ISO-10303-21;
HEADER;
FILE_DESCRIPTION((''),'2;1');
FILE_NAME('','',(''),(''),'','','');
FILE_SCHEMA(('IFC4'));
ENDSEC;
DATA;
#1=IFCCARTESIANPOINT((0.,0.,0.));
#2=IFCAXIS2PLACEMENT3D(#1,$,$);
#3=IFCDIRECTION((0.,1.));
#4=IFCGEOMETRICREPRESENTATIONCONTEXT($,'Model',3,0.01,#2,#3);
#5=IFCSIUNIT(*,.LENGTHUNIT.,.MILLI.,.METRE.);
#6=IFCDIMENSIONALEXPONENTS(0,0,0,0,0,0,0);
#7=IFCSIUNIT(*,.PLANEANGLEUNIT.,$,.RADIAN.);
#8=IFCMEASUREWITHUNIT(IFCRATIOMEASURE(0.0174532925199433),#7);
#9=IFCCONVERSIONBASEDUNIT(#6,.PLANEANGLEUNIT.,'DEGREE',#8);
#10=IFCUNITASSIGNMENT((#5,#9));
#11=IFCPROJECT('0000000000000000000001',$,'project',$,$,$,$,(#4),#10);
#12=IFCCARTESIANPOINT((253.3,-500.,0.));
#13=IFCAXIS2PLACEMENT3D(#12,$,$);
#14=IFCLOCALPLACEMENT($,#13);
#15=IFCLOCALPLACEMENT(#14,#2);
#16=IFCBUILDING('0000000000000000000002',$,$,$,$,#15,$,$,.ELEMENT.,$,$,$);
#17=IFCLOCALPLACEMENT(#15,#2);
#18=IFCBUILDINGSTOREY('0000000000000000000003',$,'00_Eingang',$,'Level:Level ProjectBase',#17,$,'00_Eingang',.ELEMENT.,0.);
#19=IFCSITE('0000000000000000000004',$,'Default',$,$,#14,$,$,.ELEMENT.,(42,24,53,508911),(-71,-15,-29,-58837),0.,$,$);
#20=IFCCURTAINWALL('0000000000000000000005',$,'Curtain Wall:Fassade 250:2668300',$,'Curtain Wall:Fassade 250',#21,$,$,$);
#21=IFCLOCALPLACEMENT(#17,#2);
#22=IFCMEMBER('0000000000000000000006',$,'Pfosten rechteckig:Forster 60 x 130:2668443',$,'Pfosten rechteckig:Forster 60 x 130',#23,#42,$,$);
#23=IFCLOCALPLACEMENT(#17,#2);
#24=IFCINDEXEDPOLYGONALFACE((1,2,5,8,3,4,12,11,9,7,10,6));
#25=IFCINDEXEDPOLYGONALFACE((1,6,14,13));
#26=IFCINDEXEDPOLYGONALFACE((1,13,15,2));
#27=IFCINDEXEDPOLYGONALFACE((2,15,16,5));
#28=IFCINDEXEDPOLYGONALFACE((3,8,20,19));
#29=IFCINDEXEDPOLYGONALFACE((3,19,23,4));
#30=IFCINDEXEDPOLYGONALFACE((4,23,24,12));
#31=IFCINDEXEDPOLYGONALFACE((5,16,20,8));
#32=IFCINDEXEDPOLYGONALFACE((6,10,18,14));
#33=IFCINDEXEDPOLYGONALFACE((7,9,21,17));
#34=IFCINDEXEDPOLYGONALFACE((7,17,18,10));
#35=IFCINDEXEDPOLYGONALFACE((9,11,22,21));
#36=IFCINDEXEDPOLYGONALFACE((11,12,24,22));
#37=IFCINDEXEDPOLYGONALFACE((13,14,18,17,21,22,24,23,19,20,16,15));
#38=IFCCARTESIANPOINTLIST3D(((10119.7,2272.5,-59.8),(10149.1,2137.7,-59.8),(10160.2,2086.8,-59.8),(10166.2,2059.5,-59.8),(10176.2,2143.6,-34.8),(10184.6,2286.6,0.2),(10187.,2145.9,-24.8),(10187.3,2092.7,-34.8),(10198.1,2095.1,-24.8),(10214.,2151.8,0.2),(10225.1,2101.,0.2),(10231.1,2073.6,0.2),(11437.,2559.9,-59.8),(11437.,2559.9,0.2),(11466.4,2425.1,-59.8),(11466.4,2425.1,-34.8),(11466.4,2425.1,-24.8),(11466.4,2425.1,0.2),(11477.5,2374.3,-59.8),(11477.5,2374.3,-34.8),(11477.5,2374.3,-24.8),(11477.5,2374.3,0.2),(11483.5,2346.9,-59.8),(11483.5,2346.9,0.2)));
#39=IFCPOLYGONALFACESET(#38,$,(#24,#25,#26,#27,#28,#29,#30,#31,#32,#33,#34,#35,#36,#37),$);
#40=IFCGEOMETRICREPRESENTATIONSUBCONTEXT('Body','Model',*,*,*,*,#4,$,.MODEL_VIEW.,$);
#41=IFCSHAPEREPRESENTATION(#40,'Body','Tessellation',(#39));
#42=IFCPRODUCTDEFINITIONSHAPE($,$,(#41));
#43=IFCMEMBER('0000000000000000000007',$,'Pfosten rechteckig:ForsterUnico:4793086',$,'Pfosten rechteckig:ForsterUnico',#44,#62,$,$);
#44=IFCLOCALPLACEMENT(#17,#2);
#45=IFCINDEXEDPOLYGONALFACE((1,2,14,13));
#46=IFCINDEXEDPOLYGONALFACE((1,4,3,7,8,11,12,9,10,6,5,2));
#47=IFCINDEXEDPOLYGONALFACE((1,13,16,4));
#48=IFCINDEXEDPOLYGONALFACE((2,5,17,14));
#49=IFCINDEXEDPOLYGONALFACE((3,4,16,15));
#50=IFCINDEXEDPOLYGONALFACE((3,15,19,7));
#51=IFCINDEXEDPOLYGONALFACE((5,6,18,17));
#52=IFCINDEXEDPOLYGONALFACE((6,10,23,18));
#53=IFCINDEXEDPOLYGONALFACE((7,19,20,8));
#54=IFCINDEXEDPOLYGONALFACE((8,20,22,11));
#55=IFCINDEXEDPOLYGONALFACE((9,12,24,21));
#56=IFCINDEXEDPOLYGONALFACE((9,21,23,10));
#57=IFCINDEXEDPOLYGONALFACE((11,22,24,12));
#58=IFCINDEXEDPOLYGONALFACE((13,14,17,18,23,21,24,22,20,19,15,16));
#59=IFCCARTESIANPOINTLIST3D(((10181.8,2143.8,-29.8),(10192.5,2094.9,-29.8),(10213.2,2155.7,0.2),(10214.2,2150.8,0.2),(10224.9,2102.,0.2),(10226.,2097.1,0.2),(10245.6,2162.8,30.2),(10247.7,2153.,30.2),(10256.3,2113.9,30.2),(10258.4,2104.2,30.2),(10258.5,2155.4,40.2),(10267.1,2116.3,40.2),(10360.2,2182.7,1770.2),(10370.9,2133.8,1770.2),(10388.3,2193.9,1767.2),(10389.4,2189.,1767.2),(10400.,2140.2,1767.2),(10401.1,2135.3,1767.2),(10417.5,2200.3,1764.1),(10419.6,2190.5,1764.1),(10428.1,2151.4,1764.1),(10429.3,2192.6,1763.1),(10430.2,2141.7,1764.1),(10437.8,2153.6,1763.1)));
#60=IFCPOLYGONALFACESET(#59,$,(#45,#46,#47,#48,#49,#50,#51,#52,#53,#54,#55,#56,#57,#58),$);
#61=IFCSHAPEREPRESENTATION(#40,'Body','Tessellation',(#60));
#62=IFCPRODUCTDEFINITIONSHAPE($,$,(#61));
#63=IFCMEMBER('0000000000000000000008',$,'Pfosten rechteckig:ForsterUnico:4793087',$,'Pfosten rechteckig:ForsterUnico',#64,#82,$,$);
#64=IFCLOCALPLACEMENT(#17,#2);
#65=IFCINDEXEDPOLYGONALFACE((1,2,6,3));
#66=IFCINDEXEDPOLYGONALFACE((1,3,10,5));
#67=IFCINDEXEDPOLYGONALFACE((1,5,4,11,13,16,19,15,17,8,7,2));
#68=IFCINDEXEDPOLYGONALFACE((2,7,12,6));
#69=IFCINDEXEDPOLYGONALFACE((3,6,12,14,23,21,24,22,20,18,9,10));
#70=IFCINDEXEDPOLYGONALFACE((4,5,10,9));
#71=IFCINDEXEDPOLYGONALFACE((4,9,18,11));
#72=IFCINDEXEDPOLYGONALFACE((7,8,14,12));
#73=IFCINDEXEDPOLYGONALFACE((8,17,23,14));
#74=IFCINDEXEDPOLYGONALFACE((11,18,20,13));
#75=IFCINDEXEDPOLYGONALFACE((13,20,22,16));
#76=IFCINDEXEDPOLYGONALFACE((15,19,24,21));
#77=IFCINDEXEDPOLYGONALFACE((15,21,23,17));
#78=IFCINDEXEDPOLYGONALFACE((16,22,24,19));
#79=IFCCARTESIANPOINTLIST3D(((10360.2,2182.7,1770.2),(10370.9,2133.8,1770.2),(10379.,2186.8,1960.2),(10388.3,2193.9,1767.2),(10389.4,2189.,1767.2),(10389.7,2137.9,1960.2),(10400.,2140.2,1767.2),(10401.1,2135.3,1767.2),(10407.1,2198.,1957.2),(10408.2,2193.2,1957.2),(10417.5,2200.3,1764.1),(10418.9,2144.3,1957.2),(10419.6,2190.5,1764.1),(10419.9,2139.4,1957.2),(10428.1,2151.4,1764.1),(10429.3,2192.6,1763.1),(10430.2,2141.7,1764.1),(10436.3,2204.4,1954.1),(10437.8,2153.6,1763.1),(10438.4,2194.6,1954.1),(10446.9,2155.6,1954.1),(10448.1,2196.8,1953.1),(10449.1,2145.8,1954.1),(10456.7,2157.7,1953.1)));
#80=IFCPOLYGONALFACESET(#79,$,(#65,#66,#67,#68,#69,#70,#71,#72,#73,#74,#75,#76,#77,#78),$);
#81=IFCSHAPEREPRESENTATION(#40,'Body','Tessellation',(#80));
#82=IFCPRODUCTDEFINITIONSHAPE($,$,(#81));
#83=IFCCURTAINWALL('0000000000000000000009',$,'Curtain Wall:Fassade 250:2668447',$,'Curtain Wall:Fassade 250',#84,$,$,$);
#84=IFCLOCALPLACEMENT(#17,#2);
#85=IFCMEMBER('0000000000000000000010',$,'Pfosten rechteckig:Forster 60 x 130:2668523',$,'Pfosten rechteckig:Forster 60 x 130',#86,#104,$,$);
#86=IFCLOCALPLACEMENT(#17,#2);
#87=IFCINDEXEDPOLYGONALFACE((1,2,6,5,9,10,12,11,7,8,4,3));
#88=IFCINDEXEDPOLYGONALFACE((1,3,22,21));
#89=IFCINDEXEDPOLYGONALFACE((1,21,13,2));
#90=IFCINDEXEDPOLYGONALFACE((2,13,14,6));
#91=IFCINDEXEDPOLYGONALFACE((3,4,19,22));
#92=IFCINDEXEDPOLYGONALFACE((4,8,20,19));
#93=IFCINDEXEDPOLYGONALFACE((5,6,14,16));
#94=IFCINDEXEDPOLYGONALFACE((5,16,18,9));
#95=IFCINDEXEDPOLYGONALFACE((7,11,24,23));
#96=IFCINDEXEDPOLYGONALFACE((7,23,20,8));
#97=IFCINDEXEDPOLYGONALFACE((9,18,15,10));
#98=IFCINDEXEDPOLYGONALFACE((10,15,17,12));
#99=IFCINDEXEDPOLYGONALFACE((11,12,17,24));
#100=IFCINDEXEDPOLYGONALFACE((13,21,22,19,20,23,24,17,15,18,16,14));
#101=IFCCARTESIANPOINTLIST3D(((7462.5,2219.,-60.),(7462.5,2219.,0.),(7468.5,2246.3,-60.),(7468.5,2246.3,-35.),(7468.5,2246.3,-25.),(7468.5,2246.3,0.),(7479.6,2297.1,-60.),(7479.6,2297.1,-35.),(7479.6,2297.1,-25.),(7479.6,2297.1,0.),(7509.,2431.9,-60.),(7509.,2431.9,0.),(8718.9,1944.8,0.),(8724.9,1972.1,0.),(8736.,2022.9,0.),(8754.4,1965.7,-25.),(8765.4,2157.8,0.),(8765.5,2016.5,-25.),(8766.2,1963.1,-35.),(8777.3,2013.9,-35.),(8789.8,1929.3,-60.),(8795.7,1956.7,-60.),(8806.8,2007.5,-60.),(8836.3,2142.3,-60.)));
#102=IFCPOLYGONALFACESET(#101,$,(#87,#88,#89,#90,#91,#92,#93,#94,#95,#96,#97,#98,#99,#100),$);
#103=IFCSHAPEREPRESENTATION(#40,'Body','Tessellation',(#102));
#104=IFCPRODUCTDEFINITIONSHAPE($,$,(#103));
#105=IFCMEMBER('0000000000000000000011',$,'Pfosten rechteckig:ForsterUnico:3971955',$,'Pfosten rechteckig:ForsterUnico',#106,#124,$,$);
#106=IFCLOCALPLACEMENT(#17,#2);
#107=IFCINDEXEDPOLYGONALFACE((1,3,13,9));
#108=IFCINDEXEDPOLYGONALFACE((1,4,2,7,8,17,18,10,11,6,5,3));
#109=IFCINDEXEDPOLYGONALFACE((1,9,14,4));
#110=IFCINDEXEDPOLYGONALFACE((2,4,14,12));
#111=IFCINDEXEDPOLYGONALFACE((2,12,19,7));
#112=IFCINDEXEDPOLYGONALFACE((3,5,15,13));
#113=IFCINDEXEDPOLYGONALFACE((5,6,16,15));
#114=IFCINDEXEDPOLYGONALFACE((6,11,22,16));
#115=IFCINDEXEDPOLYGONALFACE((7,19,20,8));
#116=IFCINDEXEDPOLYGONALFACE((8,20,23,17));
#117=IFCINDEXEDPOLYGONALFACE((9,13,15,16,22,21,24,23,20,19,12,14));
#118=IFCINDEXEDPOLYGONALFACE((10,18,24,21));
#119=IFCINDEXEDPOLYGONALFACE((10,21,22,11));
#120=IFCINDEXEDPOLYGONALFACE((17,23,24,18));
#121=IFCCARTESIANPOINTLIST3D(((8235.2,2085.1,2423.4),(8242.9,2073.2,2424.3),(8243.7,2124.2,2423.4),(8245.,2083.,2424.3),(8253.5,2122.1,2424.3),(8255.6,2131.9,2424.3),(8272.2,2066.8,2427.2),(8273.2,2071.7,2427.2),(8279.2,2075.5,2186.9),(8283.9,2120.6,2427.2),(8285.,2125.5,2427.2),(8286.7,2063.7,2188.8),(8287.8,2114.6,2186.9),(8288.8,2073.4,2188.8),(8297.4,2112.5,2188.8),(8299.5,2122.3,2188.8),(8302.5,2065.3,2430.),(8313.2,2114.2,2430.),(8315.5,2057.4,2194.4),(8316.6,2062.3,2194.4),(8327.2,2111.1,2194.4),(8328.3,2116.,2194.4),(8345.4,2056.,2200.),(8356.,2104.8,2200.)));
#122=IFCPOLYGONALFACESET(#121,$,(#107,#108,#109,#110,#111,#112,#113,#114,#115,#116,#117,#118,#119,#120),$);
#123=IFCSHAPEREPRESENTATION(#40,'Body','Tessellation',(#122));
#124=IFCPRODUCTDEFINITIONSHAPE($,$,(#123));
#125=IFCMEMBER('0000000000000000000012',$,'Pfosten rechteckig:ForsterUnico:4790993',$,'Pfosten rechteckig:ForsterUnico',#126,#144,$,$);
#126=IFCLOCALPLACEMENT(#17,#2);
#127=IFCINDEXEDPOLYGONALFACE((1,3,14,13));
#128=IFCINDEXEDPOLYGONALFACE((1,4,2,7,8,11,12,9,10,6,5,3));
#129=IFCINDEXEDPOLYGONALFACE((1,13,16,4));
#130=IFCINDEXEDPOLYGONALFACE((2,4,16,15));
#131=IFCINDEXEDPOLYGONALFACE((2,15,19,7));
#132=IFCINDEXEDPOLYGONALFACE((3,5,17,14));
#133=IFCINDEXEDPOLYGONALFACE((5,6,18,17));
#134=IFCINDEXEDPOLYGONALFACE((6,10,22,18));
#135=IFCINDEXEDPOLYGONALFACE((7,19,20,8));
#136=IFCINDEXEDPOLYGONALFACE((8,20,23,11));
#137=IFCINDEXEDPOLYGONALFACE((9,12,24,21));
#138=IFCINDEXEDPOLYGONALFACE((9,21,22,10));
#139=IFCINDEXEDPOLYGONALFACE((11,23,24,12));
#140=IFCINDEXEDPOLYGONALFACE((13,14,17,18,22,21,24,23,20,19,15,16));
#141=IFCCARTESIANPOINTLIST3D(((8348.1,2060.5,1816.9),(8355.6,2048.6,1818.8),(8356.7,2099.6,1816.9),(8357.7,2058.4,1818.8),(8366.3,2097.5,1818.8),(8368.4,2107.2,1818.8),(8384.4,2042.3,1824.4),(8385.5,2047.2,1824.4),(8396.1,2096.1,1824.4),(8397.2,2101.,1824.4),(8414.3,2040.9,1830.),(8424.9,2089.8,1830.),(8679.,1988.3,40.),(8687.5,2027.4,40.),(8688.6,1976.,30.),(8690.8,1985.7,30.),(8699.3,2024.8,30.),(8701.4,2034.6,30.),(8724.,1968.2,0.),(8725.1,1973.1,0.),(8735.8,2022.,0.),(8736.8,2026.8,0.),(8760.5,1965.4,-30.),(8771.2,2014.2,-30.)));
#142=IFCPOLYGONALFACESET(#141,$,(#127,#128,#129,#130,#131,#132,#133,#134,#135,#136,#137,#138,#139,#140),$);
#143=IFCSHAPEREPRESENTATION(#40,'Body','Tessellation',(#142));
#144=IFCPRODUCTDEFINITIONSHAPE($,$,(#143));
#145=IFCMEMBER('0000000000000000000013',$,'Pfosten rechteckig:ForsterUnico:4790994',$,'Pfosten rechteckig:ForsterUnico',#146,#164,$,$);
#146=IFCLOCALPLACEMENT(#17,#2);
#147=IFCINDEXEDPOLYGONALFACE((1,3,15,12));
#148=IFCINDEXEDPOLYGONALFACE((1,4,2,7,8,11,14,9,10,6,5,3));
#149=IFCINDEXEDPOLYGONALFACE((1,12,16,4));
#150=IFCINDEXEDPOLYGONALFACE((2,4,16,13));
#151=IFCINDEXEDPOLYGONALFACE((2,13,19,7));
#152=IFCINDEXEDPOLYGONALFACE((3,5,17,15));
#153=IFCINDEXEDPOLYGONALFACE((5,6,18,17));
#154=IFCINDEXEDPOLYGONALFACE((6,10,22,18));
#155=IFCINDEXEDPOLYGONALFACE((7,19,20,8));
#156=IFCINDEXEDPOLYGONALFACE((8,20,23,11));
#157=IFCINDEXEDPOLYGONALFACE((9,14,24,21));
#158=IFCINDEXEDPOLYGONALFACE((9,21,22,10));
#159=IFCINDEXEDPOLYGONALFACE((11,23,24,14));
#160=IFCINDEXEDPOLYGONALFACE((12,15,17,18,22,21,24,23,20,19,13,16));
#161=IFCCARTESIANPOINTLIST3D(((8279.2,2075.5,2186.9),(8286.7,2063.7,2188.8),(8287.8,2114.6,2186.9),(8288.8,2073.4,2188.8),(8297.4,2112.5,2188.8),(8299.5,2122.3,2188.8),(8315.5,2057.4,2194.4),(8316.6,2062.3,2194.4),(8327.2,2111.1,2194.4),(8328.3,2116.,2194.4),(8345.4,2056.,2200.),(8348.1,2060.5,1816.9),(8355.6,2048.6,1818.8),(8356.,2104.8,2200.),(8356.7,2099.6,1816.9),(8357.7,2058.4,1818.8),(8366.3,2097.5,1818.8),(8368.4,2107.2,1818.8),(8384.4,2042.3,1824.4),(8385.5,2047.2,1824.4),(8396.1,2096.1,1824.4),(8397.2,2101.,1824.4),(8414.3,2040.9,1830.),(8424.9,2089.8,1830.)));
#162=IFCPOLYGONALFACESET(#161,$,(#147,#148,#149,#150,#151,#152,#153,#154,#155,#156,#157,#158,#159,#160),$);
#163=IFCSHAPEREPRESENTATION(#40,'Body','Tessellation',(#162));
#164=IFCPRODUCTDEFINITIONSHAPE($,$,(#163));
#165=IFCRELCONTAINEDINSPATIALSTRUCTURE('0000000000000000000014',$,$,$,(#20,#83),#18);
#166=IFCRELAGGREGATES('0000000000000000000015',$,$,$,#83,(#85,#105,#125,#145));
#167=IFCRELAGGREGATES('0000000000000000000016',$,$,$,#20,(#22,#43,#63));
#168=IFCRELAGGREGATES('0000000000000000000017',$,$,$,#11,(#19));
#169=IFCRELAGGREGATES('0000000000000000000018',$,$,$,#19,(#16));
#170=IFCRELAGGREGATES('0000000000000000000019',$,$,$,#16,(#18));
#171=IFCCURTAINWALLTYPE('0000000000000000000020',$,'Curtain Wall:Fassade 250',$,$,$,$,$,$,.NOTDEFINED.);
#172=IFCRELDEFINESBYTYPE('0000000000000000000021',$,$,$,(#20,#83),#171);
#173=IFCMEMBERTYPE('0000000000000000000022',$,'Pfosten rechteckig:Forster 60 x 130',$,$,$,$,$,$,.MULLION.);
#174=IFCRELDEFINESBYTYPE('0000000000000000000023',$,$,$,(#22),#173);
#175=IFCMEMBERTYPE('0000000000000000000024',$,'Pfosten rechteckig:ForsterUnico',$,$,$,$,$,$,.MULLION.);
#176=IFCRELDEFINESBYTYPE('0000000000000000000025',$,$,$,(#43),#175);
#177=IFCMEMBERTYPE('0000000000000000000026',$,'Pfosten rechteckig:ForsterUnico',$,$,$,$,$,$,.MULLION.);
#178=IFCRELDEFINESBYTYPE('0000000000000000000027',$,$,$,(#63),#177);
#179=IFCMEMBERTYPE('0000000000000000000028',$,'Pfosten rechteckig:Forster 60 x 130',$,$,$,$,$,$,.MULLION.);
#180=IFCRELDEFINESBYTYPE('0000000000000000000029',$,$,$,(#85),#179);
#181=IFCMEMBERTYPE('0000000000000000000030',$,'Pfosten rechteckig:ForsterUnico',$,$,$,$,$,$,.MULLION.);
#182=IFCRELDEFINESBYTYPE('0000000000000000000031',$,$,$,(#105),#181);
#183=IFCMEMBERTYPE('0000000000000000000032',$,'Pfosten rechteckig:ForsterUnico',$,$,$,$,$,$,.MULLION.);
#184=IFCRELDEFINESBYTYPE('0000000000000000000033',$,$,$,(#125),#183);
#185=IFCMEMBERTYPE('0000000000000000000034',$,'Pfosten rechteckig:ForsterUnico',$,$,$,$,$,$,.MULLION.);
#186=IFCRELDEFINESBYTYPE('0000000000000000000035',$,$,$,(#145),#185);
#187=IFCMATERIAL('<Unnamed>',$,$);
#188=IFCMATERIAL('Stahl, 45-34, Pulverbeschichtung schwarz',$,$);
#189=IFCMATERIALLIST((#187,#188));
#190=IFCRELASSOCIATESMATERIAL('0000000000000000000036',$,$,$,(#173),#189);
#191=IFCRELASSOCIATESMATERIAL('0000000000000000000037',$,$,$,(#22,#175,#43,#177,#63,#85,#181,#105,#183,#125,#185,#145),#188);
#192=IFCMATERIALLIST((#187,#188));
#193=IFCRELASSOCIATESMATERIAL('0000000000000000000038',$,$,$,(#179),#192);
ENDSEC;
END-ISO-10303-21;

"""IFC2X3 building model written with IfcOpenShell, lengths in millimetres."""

from ifc_helpers import new_model, entity, si_unit, converted_unit, direction, frame, origin, place, context, subcontext, project, spatial, polyline, outline, extrude, clip, halfspace, source, transform, mapped, material, material_list, type_object, type_shapes, element, aggregate, save


model = new_model("IFC2X3")

# Units and contexts
model_context = context("Model", 3, precision=0.01, world=origin(), true_north=direction((0.0, 1.0)))
body_context = subcontext(model_context, "Body", "Model", "MODEL_VIEW")
ifc_project = project(units=[si_unit("LENGTHUNIT", "METRE", prefix="MILLI"), converted_unit("PLANEANGLEUNIT", "DEGREE", entity("IfcRatioMeasure", 0.0174532925199433), si_unit("PLANEANGLEUNIT", "RADIAN"), dimensions=[0, 0, 0, 0, 0, 0, 0])], contexts=[model_context])

# Site, building, storey
site_placement = place(None, frame((253.3, -500.0, 0.0)))
site = spatial("IfcSite", under=ifc_project, at=site_placement, Name="Default", CompositionType="ELEMENT", RefLatitude=(42, 24, 53, 508911), RefLongitude=(-71, -15, -29, -58837), RefElevation=0.0)
building_placement = place(site_placement, origin())
building = spatial("IfcBuilding", under=site, at=building_placement, CompositionType="ELEMENT")
storey_placement = place(building_placement, origin())
storey = spatial("IfcBuildingStorey", under=building, at=storey_placement, Name="00_Eingang", ObjectType="Level:Level ProjectBase", LongName="00_Eingang", CompositionType="ELEMENT", Elevation=0.0)

# Curtain walls, members
curtain_wall_type = type_object("IfcCurtainWallType", Name="Curtain Wall:Fassade 250", PredefinedType="NOTDEFINED")
curtain_wall_1_placement = place(storey_placement, origin())
curtain_wall_1 = element("IfcCurtainWall", 1, at=curtain_wall_1_placement, inside=storey, type_object=curtain_wall_type, Name="Curtain Wall:Fassade 250:2668300", ObjectType="Curtain Wall:Fassade 250")
ifc_material_1 = material(Name="Stahl, 45-34, Pulverbeschichtung schwarz")
ifc_material_2 = material(Name="<Unnamed>")
ifc_material_list_1 = material_list([ifc_material_2, ifc_material_1])
member_type_1 = type_object("IfcMemberType", Name="Pfosten rechteckig:Forster 60 x 130", PredefinedType="MULLION", material=ifc_material_list_1)
shared_shape_1 = source(origin(), body_context, "Body", "Clipping", [
    clip(extrude(outline(polyline([(-72.3, -30.0), (-44.3, -30.0), (-44.3, -5.0), (7.7, -5.0), (7.7, -30.0), (145.7, -30.0), (145.7, 30.0), (7.7, 30.0), (7.7, 5.0), (-44.3, 5.0), (-44.3, 30.0), (-72.3, 30.0), (-72.3, -30.0)])), frame((0.0, -18.3, -1348.3), z_axis=(0.0, 0.0, 1.0), x_axis=(0.0, -1.0, 0.0)), (0.0, 0.0, 1.0), 1348.3), halfspace(frame((0.0, 0.0, -1315.1), z_axis=(0.741933, 0.0, -0.670474), x_axis=(0.670474, 0.0, 0.741933)), False)),
])
type_shapes(member_type_1, [shared_shape_1])
member_1_placement = place(storey_placement, frame((11471.9, 2399.7, -29.8), z_axis=(0.977008, 0.213201, 0.0), x_axis=(0.0, 0.0, 1.0)))
member_1 = element("IfcMember", 2, at=member_1_placement, type_object=member_type_1, material=ifc_material_1, Name="Pfosten rechteckig:Forster 60 x 130:2668443", ObjectType="Pfosten rechteckig:Forster 60 x 130", context=body_context, shape_type="MappedRepresentation", body=[
    mapped(shared_shape_1, transform((0.0, 0.0, 0.0), scale=1.0)),
])
member_type_2 = type_object("IfcMemberType", Name="Pfosten rechteckig:ForsterUnico", PredefinedType="MULLION", material=ifc_material_1)
shared_shape_2 = source(origin(), body_context, "Body", "Clipping", [
    clip(extrude(outline(polyline([(-20.0, -28.3), (20.0, -28.3), (20.0, -18.3), (30.0, -18.3), (30.0, 11.7), (25.0, 11.7), (25.0, 41.7), (-25.0, 41.7), (-25.0, 11.7), (-30.0, 11.7), (-30.0, -18.3), (-20.0, -18.3), (-20.0, -28.3)])), frame((-41.7, 0.0, -1809.2), z_axis=(0.0, 0.0, 1.0), x_axis=(0.0, -1.0, 0.0)), (0.0, 0.0, 1.0), 1809.2), halfspace(frame((0.0, 0.0, -1809.2), z_axis=(-0.741933, 0.0, -0.670474), x_axis=(-0.670474, 0.0, 0.741933)), False)),
])
type_shapes(member_type_2, [shared_shape_2])
member_2_placement = place(storey_placement, frame((10365.5, 2158.3, 1770.2), z_axis=(0.098609, 0.021518, 0.994894), x_axis=(-0.972019, -0.212112, 0.100929)))
member_2 = element("IfcMember", 3, at=member_2_placement, type_object=member_type_2, material=ifc_material_1, Name="Pfosten rechteckig:ForsterUnico:4793086", ObjectType="Pfosten rechteckig:ForsterUnico", context=body_context, shape_type="MappedRepresentation", body=[
    mapped(shared_shape_2, transform((0.0, 0.0, 0.0), scale=1.0)),
])
member_type_3 = type_object("IfcMemberType", Name="Pfosten rechteckig:ForsterUnico", PredefinedType="MULLION", material=ifc_material_1)
shared_shape_3 = source(origin(), body_context, "Body", "SweptSolid", [
    extrude(outline(polyline([(-20.0, -28.3), (20.0, -28.3), (20.0, -18.3), (30.0, -18.3), (30.0, 11.7), (25.0, 11.7), (25.0, 41.7), (-25.0, 41.7), (-25.0, 11.7), (-30.0, 11.7), (-30.0, -18.3), (-20.0, -18.3), (-20.0, -28.3)])), frame((-41.7, 0.0, -191.0), z_axis=(0.0, 0.0, 1.0), x_axis=(0.0, -1.0, 0.0)), (0.0, 0.0, 1.0), 191.0),
])
type_shapes(member_type_3, [shared_shape_3])
member_3_placement = place(storey_placement, frame((10384.4, 2162.4, 1960.2), z_axis=(0.098609, 0.021518, 0.994894), x_axis=(-0.972019, -0.212112, 0.100929)))
member_3 = element("IfcMember", 4, at=member_3_placement, type_object=member_type_3, material=ifc_material_1, Name="Pfosten rechteckig:ForsterUnico:4793087", ObjectType="Pfosten rechteckig:ForsterUnico", context=body_context, shape_type="MappedRepresentation", body=[
    mapped(shared_shape_3, transform((0.0, 0.0, 0.0), scale=1.0)),
])
curtain_wall_2_placement = place(storey_placement, origin())
curtain_wall_2 = element("IfcCurtainWall", 5, at=curtain_wall_2_placement, inside=storey, type_object=curtain_wall_type, Name="Curtain Wall:Fassade 250:2668447", ObjectType="Curtain Wall:Fassade 250")
ifc_material_list_2 = material_list([ifc_material_2, ifc_material_1])
member_type_4 = type_object("IfcMemberType", Name="Pfosten rechteckig:Forster 60 x 130", PredefinedType="MULLION", material=ifc_material_list_2)
shared_shape_4 = source(origin(), body_context, "Body", "Clipping", [
    clip(extrude(outline(polyline([(-145.7, -30.0), (-7.7, -30.0), (-7.7, -5.0), (44.3, -5.0), (44.3, -30.0), (72.3, -30.0), (72.3, 30.0), (44.3, 30.0), (44.3, 5.0), (-7.7, 5.0), (-7.7, 30.0), (-145.7, 30.0), (-145.7, -30.0)])), frame((0.0, 18.3, -1358.5), z_axis=(0.0, 0.0, 1.0), x_axis=(0.0, -1.0, 0.0)), (0.0, 0.0, 1.0), 1358.5), halfspace(frame((0.0, 0.0, -1322.2), z_axis=(0.770451, 0.0, -0.637499), x_axis=(0.637499, 0.0, 0.770451)), False)),
])
type_shapes(member_type_4, [shared_shape_4])
member_4_placement = place(storey_placement, frame((7474.0, 2271.7, -30.0), z_axis=(-0.977008, 0.213201, 0.0), x_axis=(0.0, 0.0, 1.0)))
member_4 = element("IfcMember", 6, at=member_4_placement, type_object=member_type_4, material=ifc_material_1, Name="Pfosten rechteckig:Forster 60 x 130:2668523", ObjectType="Pfosten rechteckig:Forster 60 x 130", context=body_context, shape_type="MappedRepresentation", body=[
    mapped(shared_shape_4, transform((0.0, 0.0, 0.0), scale=1.0)),
])
member_type_5 = type_object("IfcMemberType", Name="Pfosten rechteckig:ForsterUnico", PredefinedType="MULLION", material=ifc_material_1)
shared_shape_5 = source(origin(), body_context, "Body", "Clipping", [
    clip(extrude(outline(polyline([(-20.0, -28.3), (20.0, -28.3), (20.0, -18.3), (30.0, -18.3), (30.0, 11.7), (25.0, 11.7), (25.0, 41.7), (-25.0, 41.7), (-25.0, 11.7), (-30.0, 11.7), (-30.0, -18.3), (-20.0, -18.3), (-20.0, -28.3)])), frame((-41.7, 0.0, -234.1), z_axis=(0.0, 0.0, 1.0), x_axis=(0.0, -1.0, 0.0)), (0.0, 0.0, 1.0), 240.7), halfspace(frame((0.0, 304.8, 0.0), z_axis=(0.094011, 0.0, 0.995571), x_axis=(0.995571, 0.0, -0.094011)), False)),
])
type_shapes(member_type_5, [shared_shape_5])
member_5_placement = place(storey_placement, frame((8307.9, 2089.7, 2430.0), z_axis=(-0.182886, 0.039909, 0.982324), x_axis=(0.959739, -0.209432, 0.18719)))
member_5 = element("IfcMember", 7, at=member_5_placement, type_object=member_type_5, material=ifc_material_1, Name="Pfosten rechteckig:ForsterUnico:3971955", ObjectType="Pfosten rechteckig:ForsterUnico", context=body_context, shape_type="MappedRepresentation", body=[
    mapped(shared_shape_5, transform((0.0, 0.0, 0.0), scale=1.0)),
])
member_type_6 = type_object("IfcMemberType", Name="Pfosten rechteckig:ForsterUnico", PredefinedType="MULLION", material=ifc_material_1)
shared_shape_6 = source(origin(), body_context, "Body", "Clipping", [
    clip(extrude(outline(polyline([(-20.0, -28.3), (20.0, -28.3), (20.0, -18.3), (30.0, -18.3), (30.0, 11.7), (25.0, 11.7), (25.0, 41.7), (-25.0, 41.7), (-25.0, 11.7), (-30.0, 11.7), (-30.0, -18.3), (-20.0, -18.3), (-20.0, -28.3)])), frame((-41.7, 0.0, -1893.5), z_axis=(0.0, 0.0, 1.0), x_axis=(0.0, -1.0, 0.0)), (0.0, 0.0, 1.0), 1893.5), halfspace(frame((0.0, 0.0, -1893.5), z_axis=(-0.770451, 0.0, -0.637499), x_axis=(-0.637499, 0.0, 0.770451)), False)),
])
type_shapes(member_type_6, [shared_shape_6])
member_6_placement = place(storey_placement, frame((8419.6, 2065.4, 1830.0), z_axis=(-0.182886, 0.039909, 0.982324), x_axis=(0.959739, -0.209432, 0.18719)))
member_6 = element("IfcMember", 8, at=member_6_placement, type_object=member_type_6, material=ifc_material_1, Name="Pfosten rechteckig:ForsterUnico:4790993", ObjectType="Pfosten rechteckig:ForsterUnico", context=body_context, shape_type="MappedRepresentation", body=[
    mapped(shared_shape_6, transform((0.0, 0.0, 0.0), scale=1.0)),
])
member_type_7 = type_object("IfcMemberType", Name="Pfosten rechteckig:ForsterUnico", PredefinedType="MULLION", material=ifc_material_1)
shared_shape_7 = source(origin(), body_context, "Body", "SweptSolid", [
    extrude(outline(polyline([(-20.0, -28.3), (20.0, -28.3), (20.0, -18.3), (30.0, -18.3), (30.0, 11.7), (25.0, 11.7), (25.0, 41.7), (-25.0, 41.7), (-25.0, 11.7), (-30.0, 11.7), (-30.0, -18.3), (-20.0, -18.3), (-20.0, -28.3)])), frame((-41.7, 0.0, -376.7), z_axis=(0.0, 0.0, 1.0), x_axis=(0.0, -1.0, 0.0)), (0.0, 0.0, 1.0), 376.7),
])
type_shapes(member_type_7, [shared_shape_7])
member_7_placement = place(storey_placement, frame((8350.7, 2080.4, 2200.0), z_axis=(-0.182886, 0.039909, 0.982324), x_axis=(0.959739, -0.209432, 0.18719)))
member_7 = element("IfcMember", 9, at=member_7_placement, type_object=member_type_7, material=ifc_material_1, Name="Pfosten rechteckig:ForsterUnico:4790994", ObjectType="Pfosten rechteckig:ForsterUnico", context=body_context, shape_type="MappedRepresentation", body=[
    mapped(shared_shape_7, transform((0.0, 0.0, 0.0), scale=1.0)),
])

aggregate(curtain_wall_2, [member_4, member_5, member_6, member_7])

aggregate(curtain_wall_1, [member_1, member_2, member_3])

save(model, "model.ifc")
